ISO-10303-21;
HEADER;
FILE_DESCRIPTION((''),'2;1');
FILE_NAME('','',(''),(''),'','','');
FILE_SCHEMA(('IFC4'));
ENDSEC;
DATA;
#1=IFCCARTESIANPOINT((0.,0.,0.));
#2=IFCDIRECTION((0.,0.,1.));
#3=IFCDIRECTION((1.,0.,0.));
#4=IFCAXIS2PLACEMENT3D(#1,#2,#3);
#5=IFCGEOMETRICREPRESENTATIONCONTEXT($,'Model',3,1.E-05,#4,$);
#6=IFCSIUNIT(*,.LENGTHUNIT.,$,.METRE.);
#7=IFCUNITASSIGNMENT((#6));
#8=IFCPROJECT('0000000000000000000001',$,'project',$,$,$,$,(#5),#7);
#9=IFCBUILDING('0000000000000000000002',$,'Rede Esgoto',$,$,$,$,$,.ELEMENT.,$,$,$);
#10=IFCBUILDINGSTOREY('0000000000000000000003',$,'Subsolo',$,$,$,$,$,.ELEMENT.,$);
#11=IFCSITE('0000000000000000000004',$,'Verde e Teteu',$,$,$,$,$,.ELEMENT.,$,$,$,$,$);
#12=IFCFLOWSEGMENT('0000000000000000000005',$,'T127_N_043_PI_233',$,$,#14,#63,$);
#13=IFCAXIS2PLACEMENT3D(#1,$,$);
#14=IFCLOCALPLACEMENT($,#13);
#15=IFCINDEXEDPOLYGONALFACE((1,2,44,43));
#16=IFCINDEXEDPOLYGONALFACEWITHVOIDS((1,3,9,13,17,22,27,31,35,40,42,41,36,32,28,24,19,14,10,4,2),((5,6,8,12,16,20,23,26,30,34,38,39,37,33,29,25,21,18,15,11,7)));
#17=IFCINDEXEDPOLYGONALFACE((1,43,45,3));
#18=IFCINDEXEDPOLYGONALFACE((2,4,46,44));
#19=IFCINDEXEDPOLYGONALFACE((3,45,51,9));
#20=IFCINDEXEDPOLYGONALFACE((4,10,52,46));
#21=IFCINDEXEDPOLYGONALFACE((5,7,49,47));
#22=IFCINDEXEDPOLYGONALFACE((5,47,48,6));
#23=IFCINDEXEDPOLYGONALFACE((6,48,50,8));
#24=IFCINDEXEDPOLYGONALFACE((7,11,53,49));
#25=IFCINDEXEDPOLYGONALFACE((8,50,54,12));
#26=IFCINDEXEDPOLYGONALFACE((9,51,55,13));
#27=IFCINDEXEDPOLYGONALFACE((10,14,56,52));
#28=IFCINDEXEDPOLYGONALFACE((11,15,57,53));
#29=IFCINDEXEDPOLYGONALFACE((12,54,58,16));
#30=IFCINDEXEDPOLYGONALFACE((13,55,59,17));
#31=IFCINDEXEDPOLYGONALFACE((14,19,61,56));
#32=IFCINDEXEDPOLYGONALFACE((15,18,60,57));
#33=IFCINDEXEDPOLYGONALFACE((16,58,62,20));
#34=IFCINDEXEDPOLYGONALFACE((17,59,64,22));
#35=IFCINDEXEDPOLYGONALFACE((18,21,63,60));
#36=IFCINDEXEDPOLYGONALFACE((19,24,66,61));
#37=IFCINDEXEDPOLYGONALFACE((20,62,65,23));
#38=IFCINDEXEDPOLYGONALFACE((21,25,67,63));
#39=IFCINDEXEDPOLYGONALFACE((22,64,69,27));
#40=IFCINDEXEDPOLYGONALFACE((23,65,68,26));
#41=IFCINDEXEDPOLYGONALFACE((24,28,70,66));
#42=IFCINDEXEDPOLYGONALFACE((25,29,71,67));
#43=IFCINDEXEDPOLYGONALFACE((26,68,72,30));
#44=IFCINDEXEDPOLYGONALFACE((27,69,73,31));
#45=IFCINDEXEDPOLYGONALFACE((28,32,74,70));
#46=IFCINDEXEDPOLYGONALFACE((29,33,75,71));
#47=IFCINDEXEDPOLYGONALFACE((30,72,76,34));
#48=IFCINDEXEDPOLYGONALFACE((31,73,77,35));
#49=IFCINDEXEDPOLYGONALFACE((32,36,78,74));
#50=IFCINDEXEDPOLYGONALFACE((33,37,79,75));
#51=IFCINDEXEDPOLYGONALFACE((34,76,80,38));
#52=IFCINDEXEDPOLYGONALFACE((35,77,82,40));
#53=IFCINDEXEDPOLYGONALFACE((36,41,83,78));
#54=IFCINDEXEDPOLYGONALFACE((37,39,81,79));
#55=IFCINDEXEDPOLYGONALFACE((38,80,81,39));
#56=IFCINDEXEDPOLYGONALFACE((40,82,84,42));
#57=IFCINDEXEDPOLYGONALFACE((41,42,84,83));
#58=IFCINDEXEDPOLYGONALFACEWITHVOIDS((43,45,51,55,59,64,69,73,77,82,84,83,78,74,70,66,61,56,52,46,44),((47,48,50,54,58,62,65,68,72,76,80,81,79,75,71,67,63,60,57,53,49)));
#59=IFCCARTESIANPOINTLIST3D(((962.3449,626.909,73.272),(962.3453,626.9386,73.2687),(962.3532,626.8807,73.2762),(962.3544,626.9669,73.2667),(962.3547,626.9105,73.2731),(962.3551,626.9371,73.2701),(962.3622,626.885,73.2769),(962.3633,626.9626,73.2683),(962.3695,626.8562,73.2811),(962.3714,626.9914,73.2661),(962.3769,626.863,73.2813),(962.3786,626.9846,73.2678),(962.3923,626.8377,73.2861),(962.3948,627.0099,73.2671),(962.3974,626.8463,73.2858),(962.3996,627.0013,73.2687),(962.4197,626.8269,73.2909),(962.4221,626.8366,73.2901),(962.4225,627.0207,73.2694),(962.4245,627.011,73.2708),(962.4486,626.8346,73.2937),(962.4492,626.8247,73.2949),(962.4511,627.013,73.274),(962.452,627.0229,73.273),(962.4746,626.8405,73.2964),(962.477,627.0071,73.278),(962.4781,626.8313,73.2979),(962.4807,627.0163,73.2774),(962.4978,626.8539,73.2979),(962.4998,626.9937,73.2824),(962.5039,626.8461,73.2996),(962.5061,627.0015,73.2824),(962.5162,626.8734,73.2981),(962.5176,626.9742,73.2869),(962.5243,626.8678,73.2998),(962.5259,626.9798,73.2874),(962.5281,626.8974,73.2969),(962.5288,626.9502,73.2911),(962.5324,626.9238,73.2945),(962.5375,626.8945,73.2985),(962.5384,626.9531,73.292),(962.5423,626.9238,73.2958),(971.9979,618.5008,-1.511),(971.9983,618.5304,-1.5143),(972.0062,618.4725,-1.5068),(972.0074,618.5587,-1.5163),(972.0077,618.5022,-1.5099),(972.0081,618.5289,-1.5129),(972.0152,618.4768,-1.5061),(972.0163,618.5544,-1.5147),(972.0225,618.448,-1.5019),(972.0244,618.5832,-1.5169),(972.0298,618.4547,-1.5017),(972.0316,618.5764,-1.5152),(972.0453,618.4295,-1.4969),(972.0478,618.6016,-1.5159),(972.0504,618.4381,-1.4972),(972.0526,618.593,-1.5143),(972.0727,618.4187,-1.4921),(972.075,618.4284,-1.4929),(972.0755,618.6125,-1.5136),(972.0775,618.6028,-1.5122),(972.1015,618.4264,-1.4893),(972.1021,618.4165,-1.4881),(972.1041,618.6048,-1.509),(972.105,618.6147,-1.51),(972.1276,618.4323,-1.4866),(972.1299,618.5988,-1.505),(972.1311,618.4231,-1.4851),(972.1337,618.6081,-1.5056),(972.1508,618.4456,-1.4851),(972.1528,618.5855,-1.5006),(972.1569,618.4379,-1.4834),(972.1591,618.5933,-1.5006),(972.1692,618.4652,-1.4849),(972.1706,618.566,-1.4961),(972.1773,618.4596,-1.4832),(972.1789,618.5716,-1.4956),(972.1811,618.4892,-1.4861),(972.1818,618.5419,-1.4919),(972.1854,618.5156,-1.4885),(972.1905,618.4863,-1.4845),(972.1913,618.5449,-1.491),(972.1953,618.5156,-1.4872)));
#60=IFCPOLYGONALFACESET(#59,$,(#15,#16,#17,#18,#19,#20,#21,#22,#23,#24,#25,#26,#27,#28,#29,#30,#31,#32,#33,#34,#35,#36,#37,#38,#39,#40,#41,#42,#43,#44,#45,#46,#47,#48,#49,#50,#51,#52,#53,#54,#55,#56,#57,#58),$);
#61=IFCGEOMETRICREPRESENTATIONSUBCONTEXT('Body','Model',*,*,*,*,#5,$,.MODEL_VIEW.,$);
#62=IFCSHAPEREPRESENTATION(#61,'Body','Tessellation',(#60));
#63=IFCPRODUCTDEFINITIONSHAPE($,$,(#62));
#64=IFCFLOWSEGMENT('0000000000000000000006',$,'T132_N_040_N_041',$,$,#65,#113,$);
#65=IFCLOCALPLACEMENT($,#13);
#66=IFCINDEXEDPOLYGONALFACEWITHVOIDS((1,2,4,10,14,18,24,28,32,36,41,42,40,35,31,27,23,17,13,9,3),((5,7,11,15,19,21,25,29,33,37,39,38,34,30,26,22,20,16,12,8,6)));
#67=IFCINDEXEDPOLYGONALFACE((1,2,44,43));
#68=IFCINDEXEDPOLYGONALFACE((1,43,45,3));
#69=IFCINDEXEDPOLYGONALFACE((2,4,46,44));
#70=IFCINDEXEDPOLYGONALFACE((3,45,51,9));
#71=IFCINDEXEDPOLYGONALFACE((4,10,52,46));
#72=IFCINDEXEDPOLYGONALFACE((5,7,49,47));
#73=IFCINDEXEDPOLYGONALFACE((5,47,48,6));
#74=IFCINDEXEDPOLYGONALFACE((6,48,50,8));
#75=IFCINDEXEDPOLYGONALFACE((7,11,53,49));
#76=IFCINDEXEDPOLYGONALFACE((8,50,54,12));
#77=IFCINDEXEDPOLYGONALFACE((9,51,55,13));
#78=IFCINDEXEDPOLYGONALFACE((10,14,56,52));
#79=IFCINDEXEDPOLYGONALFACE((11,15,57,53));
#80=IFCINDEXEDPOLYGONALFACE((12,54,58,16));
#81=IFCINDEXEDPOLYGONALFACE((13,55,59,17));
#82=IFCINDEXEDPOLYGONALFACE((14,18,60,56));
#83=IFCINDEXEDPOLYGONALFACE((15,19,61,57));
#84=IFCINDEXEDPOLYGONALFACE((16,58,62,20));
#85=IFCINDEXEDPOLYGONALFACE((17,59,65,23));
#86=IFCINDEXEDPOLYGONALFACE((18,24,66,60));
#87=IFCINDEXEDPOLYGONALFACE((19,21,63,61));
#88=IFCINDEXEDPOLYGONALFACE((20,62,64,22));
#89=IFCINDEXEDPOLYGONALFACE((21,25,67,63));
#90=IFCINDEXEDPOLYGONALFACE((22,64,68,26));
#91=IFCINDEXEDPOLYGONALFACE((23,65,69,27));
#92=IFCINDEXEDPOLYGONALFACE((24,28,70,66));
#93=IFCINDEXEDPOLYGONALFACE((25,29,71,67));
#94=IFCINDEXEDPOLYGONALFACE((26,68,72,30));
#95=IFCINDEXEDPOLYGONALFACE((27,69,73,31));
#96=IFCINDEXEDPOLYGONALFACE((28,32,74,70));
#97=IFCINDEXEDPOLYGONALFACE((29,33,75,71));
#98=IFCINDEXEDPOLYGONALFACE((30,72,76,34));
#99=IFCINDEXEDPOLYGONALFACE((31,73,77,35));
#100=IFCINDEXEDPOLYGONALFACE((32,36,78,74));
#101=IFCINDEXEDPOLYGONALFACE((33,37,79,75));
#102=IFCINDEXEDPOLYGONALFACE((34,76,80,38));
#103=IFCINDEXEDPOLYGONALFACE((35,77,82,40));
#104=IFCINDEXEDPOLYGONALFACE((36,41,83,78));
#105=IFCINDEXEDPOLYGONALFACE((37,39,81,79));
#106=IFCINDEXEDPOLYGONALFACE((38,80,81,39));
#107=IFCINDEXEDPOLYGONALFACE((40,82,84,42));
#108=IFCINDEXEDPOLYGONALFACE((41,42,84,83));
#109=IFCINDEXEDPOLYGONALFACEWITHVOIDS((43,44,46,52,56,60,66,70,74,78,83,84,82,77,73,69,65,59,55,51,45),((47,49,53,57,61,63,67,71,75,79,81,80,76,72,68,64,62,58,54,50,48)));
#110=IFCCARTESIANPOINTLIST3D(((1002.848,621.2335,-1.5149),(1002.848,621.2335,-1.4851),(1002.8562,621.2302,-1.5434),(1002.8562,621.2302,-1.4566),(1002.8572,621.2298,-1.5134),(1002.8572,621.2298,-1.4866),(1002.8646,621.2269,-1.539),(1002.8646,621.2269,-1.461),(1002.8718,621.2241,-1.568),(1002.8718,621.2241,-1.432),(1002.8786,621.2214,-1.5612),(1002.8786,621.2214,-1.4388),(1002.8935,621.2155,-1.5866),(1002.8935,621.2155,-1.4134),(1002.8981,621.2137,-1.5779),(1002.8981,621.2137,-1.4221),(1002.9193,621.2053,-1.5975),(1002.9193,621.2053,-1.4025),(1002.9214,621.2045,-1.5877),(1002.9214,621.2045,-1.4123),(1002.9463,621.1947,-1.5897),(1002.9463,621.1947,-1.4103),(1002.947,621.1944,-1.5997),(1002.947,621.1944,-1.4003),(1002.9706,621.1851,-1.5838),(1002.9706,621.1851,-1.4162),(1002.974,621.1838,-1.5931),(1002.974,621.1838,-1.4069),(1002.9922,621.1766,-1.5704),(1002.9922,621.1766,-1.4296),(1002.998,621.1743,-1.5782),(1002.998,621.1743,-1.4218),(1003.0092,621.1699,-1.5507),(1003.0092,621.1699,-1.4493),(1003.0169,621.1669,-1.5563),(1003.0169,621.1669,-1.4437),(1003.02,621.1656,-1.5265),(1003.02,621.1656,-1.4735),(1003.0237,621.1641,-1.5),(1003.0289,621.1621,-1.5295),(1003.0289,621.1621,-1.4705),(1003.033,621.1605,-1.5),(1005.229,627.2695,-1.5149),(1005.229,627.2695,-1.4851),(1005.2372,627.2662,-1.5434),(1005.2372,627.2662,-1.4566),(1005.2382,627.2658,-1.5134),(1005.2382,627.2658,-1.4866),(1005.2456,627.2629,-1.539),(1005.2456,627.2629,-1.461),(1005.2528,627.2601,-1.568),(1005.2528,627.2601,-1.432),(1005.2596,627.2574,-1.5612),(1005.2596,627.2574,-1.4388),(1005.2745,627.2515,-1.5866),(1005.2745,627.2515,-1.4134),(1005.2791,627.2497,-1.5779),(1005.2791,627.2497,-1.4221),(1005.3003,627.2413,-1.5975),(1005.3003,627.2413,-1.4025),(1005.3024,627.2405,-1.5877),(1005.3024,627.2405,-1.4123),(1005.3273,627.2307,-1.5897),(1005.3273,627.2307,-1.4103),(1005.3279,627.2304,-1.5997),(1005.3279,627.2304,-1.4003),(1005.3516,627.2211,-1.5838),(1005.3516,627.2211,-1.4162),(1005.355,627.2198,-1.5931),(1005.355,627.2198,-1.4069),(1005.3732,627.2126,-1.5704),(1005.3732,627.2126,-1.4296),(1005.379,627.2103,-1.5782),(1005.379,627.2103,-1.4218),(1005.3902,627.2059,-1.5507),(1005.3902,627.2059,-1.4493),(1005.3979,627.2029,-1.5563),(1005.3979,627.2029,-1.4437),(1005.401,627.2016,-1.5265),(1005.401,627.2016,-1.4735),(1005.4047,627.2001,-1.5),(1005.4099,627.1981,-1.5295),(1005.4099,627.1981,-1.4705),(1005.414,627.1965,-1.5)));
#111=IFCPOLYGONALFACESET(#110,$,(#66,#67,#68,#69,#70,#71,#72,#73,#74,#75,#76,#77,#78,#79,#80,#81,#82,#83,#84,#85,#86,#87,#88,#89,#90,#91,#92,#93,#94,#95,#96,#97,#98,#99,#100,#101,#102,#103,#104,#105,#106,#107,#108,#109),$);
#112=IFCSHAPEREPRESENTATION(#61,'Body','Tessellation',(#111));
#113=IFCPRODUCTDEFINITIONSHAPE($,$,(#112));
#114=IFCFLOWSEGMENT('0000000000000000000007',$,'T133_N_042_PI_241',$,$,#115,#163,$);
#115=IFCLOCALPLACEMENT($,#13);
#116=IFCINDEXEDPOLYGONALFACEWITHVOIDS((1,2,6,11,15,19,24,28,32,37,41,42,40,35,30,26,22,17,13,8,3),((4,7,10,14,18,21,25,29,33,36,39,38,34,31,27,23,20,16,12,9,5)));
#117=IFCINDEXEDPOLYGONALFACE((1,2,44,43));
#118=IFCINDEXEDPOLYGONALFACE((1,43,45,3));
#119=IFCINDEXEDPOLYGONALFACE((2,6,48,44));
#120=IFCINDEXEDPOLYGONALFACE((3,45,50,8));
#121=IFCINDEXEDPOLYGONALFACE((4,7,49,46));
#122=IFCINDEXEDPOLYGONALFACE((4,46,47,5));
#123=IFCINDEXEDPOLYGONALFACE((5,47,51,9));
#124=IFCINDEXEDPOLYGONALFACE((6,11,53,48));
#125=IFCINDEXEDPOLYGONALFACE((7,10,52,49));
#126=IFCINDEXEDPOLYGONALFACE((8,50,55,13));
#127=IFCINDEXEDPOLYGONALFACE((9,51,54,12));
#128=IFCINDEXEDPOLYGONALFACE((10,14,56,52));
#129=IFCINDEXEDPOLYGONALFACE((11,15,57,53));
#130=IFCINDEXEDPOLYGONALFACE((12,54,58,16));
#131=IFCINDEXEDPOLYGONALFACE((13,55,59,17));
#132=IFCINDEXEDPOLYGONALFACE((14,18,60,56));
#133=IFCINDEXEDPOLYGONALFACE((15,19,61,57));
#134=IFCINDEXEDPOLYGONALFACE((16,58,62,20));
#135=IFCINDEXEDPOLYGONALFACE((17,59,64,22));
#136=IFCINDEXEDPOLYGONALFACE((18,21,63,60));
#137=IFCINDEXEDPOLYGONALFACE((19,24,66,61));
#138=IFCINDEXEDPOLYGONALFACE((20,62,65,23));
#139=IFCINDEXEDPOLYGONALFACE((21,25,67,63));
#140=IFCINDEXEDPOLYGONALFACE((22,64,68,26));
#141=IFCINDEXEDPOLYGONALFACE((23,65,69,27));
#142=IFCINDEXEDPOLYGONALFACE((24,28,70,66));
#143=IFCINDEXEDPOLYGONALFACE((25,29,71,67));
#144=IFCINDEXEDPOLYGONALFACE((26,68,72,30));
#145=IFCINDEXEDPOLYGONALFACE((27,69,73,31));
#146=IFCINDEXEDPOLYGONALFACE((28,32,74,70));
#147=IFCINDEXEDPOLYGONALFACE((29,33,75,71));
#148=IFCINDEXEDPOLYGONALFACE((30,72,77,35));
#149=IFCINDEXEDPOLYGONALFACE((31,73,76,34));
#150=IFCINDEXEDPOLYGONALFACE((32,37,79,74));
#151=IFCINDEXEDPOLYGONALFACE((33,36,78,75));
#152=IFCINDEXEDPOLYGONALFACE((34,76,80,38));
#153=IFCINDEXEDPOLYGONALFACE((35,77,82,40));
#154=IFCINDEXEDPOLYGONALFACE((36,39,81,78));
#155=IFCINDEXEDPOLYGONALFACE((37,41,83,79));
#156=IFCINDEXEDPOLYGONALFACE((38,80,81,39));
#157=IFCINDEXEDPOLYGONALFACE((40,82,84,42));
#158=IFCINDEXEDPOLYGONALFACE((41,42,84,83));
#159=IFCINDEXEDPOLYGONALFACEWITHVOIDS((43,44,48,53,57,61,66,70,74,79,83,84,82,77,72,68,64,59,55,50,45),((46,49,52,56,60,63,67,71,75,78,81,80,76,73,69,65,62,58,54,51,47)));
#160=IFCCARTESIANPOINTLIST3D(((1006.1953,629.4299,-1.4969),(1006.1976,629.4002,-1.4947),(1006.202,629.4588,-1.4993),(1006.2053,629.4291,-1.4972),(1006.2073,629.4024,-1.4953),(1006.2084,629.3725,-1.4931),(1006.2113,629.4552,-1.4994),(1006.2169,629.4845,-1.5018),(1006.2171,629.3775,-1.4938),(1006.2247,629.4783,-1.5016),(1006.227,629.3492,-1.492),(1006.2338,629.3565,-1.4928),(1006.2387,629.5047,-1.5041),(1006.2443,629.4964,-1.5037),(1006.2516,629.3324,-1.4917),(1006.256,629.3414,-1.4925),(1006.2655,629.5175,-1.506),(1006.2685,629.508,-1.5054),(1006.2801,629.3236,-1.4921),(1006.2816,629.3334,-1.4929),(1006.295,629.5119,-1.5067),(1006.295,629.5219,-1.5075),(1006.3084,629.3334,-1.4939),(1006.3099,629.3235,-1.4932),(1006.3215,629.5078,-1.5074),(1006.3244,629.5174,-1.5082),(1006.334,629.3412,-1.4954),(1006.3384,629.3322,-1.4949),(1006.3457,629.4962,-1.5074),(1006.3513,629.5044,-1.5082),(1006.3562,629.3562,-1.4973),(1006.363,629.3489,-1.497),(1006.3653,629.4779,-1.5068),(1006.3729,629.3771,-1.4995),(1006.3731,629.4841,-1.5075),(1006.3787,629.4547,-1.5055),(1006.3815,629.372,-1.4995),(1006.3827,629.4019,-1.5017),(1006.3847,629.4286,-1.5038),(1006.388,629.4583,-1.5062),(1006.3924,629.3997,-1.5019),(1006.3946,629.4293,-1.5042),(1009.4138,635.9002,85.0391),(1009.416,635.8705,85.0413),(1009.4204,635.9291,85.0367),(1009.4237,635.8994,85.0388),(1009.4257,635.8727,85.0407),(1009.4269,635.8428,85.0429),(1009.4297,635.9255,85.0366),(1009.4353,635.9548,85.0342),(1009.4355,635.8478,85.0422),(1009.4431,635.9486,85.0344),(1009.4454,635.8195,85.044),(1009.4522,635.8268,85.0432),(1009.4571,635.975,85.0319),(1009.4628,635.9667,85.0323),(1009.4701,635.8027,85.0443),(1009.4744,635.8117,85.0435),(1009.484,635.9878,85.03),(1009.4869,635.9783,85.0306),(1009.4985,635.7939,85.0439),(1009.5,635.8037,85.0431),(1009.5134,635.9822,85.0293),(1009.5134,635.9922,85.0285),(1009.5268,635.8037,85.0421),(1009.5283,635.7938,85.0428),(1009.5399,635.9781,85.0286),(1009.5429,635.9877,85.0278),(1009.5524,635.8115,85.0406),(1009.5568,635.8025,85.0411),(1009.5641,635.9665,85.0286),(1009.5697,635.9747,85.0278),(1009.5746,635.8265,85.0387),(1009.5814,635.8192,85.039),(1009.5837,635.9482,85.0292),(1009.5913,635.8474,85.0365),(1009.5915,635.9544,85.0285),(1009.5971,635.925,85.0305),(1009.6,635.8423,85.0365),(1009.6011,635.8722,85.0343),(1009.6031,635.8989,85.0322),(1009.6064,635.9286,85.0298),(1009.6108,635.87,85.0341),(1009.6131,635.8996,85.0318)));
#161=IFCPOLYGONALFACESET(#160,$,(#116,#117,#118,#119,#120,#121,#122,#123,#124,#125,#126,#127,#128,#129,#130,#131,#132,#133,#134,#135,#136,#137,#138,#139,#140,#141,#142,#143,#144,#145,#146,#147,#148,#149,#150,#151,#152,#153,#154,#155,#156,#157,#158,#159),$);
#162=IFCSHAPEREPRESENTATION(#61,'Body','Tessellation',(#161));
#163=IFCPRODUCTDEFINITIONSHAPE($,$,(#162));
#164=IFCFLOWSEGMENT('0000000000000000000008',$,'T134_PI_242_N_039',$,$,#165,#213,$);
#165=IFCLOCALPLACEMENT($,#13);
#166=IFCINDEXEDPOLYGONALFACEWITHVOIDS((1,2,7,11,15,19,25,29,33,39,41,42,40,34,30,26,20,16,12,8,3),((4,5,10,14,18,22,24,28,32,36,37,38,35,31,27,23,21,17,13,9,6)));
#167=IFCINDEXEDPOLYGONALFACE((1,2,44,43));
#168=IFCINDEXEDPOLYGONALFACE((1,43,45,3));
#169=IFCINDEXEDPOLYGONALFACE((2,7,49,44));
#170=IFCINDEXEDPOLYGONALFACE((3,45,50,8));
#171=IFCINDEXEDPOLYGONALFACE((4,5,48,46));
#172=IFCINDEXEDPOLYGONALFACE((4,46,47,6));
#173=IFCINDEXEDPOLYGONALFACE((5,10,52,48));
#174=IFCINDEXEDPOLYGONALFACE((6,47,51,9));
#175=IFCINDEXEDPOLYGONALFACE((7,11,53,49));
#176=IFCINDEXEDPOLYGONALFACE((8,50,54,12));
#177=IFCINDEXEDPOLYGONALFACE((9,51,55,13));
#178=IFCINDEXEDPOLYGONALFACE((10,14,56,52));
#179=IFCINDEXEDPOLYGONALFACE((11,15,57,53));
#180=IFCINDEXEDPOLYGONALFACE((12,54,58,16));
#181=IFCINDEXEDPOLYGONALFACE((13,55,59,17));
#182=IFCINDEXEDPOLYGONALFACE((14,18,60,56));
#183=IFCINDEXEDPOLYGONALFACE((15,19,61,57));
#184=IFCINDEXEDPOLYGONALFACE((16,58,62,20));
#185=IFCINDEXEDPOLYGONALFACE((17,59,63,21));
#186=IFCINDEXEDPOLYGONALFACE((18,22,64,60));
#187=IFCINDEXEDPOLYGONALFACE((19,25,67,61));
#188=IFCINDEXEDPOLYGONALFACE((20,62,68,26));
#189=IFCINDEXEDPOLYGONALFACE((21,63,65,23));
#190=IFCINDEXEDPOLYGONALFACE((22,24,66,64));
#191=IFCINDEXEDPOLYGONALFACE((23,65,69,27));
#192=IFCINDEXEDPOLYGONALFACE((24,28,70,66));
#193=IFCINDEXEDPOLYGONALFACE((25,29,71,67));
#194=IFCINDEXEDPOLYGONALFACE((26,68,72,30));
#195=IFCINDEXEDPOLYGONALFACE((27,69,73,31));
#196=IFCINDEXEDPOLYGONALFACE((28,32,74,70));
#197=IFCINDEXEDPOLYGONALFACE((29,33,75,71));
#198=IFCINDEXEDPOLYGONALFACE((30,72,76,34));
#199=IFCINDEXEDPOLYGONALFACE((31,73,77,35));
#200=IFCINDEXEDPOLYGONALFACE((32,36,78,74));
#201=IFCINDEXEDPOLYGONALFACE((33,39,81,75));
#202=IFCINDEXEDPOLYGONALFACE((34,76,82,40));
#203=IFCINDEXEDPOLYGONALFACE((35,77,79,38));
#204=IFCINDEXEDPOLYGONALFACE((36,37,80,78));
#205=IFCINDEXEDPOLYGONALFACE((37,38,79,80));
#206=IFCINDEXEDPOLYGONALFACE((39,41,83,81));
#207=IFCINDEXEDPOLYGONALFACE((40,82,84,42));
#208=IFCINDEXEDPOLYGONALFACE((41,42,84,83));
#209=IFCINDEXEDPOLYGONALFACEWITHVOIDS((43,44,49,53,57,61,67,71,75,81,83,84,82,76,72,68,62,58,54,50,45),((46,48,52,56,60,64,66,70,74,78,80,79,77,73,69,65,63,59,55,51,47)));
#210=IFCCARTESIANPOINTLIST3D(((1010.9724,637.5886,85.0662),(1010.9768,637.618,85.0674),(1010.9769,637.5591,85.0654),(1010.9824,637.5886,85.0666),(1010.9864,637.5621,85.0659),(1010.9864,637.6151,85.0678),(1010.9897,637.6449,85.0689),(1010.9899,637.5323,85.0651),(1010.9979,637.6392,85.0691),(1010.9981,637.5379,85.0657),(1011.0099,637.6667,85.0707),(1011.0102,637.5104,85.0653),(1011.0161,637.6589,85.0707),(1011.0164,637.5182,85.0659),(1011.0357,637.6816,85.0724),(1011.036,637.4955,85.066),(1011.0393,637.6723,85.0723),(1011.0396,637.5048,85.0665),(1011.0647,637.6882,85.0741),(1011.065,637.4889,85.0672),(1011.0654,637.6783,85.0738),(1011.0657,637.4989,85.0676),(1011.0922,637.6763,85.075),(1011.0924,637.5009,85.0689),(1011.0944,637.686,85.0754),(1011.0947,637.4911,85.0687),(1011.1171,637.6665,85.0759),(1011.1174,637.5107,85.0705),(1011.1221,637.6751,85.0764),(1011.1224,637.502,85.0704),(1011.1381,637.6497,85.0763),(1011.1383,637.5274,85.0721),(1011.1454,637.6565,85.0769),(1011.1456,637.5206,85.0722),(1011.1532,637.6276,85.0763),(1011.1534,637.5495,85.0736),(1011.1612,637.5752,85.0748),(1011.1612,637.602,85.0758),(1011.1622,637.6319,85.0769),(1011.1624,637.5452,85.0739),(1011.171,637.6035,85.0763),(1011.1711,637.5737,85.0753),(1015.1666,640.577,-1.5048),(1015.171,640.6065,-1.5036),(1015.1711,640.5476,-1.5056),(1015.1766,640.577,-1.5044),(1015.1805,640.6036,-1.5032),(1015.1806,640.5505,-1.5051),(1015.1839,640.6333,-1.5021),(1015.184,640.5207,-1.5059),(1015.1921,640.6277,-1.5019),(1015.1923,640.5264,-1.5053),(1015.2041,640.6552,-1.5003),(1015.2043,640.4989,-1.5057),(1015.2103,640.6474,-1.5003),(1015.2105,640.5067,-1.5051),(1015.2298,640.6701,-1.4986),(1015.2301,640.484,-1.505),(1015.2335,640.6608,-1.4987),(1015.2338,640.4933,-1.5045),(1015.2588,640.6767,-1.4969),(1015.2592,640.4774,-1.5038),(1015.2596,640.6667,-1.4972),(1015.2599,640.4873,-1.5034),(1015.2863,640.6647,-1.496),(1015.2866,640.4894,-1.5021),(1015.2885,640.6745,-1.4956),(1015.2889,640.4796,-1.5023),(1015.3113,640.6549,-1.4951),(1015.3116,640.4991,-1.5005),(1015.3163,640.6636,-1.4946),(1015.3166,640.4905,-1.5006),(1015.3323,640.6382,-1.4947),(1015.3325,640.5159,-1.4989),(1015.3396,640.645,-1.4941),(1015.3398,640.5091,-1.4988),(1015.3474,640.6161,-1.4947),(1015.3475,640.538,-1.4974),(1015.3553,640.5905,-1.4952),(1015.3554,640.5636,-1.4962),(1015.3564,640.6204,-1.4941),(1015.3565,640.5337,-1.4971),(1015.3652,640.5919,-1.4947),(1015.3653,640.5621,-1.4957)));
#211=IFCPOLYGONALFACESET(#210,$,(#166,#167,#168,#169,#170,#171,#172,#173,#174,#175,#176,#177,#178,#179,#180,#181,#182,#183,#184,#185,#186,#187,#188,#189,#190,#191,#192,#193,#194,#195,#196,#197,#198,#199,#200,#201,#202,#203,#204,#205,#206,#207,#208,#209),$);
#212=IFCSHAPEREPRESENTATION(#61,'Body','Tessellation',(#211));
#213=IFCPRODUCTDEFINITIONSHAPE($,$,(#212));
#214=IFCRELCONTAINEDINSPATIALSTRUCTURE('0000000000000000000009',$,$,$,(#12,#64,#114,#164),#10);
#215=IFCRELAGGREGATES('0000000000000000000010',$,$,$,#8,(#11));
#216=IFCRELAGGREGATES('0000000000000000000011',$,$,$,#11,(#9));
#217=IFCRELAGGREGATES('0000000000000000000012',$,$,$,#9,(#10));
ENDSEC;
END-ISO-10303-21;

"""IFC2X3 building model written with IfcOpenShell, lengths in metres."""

from ifc_helpers import new_model, entity, si_unit, frame, origin_with_axes, place, context, subcontext, project, spatial, element, save


model = new_model("IFC2X3")

# Units and contexts
model_context = context("Model", 3, precision=1e-05, world=origin_with_axes())
body_context = subcontext(model_context, "Body", "Model", "MODEL_VIEW")
ifc_project = project(units=[si_unit("LENGTHUNIT", "METRE")], contexts=[model_context])

# Site, building, storey
site = spatial("IfcSite", under=ifc_project, Name="Verde e Teteu", CompositionType="ELEMENT")
building = spatial("IfcBuilding", under=site, Name="Rede Esgoto", CompositionType="ELEMENT")
storey = spatial("IfcBuildingStorey", under=building, Name="Subsolo", CompositionType="ELEMENT")

# Flow segments
flow_segment_1_placement = place(None, frame((972.0961, 618.5156, -1.5), z_axis=(0.0, 0.0, 1.0), x_axis=(1.0, 0.0, 0.0)))
element("IfcFlowSegment", 1, at=flow_segment_1_placement, inside=storey, Name="T127_N_043_PI_233", context=body_context, shape_type="SweptSolid", body=[
    entity("IfcSweptDiskSolid", entity("IfcPolyline", [entity("IfcCartesianPoint", [0.0, 0.0, 0.0]), entity("IfcCartesianPoint", [-9.653, 8.4082, 74.783])]), 0.1, 0.09),
])
flow_segment_2_placement = place(None, frame((1002.94, 621.1972, -1.5), z_axis=(0.0, 0.0, 1.0), x_axis=(1.0, 0.0, 0.0)))
element("IfcFlowSegment", 2, at=flow_segment_2_placement, inside=storey, Name="T132_N_040_N_041", context=body_context, shape_type="SweptSolid", body=[
    entity("IfcSweptDiskSolid", entity("IfcPolyline", [entity("IfcCartesianPoint", [0.0, 0.0, 0.0]), entity("IfcCartesianPoint", [2.381, 6.036, 0.0])]), 0.1, 0.09),
])
flow_segment_3_placement = place(None, frame((1006.295, 629.4221, -1.5), z_axis=(0.0, 0.0, 1.0), x_axis=(1.0, 0.0, 0.0)))
element("IfcFlowSegment", 3, at=flow_segment_3_placement, inside=storey, Name="T133_N_042_PI_241", context=body_context, shape_type="SweptSolid", body=[
    entity("IfcSweptDiskSolid", entity("IfcPolyline", [entity("IfcCartesianPoint", [0.0, 0.0, 0.0]), entity("IfcCartesianPoint", [3.2184, 6.4703, 86.536])]), 0.1, 0.09),
])
flow_segment_4_placement = place(None, frame((1011.0723, 637.5886, 85.071), z_axis=(0.0, 0.0, 1.0), x_axis=(1.0, 0.0, 0.0)))
element("IfcFlowSegment", 4, at=flow_segment_4_placement, inside=storey, Name="T134_PI_242_N_039", context=body_context, shape_type="SweptSolid", body=[
    entity("IfcSweptDiskSolid", entity("IfcPolyline", [entity("IfcCartesianPoint", [0.0, 0.0, 0.0]), entity("IfcCartesianPoint", [4.1942, 2.9885, -86.571])]), 0.1, 0.09),
])

save(model, "model.ifc")
